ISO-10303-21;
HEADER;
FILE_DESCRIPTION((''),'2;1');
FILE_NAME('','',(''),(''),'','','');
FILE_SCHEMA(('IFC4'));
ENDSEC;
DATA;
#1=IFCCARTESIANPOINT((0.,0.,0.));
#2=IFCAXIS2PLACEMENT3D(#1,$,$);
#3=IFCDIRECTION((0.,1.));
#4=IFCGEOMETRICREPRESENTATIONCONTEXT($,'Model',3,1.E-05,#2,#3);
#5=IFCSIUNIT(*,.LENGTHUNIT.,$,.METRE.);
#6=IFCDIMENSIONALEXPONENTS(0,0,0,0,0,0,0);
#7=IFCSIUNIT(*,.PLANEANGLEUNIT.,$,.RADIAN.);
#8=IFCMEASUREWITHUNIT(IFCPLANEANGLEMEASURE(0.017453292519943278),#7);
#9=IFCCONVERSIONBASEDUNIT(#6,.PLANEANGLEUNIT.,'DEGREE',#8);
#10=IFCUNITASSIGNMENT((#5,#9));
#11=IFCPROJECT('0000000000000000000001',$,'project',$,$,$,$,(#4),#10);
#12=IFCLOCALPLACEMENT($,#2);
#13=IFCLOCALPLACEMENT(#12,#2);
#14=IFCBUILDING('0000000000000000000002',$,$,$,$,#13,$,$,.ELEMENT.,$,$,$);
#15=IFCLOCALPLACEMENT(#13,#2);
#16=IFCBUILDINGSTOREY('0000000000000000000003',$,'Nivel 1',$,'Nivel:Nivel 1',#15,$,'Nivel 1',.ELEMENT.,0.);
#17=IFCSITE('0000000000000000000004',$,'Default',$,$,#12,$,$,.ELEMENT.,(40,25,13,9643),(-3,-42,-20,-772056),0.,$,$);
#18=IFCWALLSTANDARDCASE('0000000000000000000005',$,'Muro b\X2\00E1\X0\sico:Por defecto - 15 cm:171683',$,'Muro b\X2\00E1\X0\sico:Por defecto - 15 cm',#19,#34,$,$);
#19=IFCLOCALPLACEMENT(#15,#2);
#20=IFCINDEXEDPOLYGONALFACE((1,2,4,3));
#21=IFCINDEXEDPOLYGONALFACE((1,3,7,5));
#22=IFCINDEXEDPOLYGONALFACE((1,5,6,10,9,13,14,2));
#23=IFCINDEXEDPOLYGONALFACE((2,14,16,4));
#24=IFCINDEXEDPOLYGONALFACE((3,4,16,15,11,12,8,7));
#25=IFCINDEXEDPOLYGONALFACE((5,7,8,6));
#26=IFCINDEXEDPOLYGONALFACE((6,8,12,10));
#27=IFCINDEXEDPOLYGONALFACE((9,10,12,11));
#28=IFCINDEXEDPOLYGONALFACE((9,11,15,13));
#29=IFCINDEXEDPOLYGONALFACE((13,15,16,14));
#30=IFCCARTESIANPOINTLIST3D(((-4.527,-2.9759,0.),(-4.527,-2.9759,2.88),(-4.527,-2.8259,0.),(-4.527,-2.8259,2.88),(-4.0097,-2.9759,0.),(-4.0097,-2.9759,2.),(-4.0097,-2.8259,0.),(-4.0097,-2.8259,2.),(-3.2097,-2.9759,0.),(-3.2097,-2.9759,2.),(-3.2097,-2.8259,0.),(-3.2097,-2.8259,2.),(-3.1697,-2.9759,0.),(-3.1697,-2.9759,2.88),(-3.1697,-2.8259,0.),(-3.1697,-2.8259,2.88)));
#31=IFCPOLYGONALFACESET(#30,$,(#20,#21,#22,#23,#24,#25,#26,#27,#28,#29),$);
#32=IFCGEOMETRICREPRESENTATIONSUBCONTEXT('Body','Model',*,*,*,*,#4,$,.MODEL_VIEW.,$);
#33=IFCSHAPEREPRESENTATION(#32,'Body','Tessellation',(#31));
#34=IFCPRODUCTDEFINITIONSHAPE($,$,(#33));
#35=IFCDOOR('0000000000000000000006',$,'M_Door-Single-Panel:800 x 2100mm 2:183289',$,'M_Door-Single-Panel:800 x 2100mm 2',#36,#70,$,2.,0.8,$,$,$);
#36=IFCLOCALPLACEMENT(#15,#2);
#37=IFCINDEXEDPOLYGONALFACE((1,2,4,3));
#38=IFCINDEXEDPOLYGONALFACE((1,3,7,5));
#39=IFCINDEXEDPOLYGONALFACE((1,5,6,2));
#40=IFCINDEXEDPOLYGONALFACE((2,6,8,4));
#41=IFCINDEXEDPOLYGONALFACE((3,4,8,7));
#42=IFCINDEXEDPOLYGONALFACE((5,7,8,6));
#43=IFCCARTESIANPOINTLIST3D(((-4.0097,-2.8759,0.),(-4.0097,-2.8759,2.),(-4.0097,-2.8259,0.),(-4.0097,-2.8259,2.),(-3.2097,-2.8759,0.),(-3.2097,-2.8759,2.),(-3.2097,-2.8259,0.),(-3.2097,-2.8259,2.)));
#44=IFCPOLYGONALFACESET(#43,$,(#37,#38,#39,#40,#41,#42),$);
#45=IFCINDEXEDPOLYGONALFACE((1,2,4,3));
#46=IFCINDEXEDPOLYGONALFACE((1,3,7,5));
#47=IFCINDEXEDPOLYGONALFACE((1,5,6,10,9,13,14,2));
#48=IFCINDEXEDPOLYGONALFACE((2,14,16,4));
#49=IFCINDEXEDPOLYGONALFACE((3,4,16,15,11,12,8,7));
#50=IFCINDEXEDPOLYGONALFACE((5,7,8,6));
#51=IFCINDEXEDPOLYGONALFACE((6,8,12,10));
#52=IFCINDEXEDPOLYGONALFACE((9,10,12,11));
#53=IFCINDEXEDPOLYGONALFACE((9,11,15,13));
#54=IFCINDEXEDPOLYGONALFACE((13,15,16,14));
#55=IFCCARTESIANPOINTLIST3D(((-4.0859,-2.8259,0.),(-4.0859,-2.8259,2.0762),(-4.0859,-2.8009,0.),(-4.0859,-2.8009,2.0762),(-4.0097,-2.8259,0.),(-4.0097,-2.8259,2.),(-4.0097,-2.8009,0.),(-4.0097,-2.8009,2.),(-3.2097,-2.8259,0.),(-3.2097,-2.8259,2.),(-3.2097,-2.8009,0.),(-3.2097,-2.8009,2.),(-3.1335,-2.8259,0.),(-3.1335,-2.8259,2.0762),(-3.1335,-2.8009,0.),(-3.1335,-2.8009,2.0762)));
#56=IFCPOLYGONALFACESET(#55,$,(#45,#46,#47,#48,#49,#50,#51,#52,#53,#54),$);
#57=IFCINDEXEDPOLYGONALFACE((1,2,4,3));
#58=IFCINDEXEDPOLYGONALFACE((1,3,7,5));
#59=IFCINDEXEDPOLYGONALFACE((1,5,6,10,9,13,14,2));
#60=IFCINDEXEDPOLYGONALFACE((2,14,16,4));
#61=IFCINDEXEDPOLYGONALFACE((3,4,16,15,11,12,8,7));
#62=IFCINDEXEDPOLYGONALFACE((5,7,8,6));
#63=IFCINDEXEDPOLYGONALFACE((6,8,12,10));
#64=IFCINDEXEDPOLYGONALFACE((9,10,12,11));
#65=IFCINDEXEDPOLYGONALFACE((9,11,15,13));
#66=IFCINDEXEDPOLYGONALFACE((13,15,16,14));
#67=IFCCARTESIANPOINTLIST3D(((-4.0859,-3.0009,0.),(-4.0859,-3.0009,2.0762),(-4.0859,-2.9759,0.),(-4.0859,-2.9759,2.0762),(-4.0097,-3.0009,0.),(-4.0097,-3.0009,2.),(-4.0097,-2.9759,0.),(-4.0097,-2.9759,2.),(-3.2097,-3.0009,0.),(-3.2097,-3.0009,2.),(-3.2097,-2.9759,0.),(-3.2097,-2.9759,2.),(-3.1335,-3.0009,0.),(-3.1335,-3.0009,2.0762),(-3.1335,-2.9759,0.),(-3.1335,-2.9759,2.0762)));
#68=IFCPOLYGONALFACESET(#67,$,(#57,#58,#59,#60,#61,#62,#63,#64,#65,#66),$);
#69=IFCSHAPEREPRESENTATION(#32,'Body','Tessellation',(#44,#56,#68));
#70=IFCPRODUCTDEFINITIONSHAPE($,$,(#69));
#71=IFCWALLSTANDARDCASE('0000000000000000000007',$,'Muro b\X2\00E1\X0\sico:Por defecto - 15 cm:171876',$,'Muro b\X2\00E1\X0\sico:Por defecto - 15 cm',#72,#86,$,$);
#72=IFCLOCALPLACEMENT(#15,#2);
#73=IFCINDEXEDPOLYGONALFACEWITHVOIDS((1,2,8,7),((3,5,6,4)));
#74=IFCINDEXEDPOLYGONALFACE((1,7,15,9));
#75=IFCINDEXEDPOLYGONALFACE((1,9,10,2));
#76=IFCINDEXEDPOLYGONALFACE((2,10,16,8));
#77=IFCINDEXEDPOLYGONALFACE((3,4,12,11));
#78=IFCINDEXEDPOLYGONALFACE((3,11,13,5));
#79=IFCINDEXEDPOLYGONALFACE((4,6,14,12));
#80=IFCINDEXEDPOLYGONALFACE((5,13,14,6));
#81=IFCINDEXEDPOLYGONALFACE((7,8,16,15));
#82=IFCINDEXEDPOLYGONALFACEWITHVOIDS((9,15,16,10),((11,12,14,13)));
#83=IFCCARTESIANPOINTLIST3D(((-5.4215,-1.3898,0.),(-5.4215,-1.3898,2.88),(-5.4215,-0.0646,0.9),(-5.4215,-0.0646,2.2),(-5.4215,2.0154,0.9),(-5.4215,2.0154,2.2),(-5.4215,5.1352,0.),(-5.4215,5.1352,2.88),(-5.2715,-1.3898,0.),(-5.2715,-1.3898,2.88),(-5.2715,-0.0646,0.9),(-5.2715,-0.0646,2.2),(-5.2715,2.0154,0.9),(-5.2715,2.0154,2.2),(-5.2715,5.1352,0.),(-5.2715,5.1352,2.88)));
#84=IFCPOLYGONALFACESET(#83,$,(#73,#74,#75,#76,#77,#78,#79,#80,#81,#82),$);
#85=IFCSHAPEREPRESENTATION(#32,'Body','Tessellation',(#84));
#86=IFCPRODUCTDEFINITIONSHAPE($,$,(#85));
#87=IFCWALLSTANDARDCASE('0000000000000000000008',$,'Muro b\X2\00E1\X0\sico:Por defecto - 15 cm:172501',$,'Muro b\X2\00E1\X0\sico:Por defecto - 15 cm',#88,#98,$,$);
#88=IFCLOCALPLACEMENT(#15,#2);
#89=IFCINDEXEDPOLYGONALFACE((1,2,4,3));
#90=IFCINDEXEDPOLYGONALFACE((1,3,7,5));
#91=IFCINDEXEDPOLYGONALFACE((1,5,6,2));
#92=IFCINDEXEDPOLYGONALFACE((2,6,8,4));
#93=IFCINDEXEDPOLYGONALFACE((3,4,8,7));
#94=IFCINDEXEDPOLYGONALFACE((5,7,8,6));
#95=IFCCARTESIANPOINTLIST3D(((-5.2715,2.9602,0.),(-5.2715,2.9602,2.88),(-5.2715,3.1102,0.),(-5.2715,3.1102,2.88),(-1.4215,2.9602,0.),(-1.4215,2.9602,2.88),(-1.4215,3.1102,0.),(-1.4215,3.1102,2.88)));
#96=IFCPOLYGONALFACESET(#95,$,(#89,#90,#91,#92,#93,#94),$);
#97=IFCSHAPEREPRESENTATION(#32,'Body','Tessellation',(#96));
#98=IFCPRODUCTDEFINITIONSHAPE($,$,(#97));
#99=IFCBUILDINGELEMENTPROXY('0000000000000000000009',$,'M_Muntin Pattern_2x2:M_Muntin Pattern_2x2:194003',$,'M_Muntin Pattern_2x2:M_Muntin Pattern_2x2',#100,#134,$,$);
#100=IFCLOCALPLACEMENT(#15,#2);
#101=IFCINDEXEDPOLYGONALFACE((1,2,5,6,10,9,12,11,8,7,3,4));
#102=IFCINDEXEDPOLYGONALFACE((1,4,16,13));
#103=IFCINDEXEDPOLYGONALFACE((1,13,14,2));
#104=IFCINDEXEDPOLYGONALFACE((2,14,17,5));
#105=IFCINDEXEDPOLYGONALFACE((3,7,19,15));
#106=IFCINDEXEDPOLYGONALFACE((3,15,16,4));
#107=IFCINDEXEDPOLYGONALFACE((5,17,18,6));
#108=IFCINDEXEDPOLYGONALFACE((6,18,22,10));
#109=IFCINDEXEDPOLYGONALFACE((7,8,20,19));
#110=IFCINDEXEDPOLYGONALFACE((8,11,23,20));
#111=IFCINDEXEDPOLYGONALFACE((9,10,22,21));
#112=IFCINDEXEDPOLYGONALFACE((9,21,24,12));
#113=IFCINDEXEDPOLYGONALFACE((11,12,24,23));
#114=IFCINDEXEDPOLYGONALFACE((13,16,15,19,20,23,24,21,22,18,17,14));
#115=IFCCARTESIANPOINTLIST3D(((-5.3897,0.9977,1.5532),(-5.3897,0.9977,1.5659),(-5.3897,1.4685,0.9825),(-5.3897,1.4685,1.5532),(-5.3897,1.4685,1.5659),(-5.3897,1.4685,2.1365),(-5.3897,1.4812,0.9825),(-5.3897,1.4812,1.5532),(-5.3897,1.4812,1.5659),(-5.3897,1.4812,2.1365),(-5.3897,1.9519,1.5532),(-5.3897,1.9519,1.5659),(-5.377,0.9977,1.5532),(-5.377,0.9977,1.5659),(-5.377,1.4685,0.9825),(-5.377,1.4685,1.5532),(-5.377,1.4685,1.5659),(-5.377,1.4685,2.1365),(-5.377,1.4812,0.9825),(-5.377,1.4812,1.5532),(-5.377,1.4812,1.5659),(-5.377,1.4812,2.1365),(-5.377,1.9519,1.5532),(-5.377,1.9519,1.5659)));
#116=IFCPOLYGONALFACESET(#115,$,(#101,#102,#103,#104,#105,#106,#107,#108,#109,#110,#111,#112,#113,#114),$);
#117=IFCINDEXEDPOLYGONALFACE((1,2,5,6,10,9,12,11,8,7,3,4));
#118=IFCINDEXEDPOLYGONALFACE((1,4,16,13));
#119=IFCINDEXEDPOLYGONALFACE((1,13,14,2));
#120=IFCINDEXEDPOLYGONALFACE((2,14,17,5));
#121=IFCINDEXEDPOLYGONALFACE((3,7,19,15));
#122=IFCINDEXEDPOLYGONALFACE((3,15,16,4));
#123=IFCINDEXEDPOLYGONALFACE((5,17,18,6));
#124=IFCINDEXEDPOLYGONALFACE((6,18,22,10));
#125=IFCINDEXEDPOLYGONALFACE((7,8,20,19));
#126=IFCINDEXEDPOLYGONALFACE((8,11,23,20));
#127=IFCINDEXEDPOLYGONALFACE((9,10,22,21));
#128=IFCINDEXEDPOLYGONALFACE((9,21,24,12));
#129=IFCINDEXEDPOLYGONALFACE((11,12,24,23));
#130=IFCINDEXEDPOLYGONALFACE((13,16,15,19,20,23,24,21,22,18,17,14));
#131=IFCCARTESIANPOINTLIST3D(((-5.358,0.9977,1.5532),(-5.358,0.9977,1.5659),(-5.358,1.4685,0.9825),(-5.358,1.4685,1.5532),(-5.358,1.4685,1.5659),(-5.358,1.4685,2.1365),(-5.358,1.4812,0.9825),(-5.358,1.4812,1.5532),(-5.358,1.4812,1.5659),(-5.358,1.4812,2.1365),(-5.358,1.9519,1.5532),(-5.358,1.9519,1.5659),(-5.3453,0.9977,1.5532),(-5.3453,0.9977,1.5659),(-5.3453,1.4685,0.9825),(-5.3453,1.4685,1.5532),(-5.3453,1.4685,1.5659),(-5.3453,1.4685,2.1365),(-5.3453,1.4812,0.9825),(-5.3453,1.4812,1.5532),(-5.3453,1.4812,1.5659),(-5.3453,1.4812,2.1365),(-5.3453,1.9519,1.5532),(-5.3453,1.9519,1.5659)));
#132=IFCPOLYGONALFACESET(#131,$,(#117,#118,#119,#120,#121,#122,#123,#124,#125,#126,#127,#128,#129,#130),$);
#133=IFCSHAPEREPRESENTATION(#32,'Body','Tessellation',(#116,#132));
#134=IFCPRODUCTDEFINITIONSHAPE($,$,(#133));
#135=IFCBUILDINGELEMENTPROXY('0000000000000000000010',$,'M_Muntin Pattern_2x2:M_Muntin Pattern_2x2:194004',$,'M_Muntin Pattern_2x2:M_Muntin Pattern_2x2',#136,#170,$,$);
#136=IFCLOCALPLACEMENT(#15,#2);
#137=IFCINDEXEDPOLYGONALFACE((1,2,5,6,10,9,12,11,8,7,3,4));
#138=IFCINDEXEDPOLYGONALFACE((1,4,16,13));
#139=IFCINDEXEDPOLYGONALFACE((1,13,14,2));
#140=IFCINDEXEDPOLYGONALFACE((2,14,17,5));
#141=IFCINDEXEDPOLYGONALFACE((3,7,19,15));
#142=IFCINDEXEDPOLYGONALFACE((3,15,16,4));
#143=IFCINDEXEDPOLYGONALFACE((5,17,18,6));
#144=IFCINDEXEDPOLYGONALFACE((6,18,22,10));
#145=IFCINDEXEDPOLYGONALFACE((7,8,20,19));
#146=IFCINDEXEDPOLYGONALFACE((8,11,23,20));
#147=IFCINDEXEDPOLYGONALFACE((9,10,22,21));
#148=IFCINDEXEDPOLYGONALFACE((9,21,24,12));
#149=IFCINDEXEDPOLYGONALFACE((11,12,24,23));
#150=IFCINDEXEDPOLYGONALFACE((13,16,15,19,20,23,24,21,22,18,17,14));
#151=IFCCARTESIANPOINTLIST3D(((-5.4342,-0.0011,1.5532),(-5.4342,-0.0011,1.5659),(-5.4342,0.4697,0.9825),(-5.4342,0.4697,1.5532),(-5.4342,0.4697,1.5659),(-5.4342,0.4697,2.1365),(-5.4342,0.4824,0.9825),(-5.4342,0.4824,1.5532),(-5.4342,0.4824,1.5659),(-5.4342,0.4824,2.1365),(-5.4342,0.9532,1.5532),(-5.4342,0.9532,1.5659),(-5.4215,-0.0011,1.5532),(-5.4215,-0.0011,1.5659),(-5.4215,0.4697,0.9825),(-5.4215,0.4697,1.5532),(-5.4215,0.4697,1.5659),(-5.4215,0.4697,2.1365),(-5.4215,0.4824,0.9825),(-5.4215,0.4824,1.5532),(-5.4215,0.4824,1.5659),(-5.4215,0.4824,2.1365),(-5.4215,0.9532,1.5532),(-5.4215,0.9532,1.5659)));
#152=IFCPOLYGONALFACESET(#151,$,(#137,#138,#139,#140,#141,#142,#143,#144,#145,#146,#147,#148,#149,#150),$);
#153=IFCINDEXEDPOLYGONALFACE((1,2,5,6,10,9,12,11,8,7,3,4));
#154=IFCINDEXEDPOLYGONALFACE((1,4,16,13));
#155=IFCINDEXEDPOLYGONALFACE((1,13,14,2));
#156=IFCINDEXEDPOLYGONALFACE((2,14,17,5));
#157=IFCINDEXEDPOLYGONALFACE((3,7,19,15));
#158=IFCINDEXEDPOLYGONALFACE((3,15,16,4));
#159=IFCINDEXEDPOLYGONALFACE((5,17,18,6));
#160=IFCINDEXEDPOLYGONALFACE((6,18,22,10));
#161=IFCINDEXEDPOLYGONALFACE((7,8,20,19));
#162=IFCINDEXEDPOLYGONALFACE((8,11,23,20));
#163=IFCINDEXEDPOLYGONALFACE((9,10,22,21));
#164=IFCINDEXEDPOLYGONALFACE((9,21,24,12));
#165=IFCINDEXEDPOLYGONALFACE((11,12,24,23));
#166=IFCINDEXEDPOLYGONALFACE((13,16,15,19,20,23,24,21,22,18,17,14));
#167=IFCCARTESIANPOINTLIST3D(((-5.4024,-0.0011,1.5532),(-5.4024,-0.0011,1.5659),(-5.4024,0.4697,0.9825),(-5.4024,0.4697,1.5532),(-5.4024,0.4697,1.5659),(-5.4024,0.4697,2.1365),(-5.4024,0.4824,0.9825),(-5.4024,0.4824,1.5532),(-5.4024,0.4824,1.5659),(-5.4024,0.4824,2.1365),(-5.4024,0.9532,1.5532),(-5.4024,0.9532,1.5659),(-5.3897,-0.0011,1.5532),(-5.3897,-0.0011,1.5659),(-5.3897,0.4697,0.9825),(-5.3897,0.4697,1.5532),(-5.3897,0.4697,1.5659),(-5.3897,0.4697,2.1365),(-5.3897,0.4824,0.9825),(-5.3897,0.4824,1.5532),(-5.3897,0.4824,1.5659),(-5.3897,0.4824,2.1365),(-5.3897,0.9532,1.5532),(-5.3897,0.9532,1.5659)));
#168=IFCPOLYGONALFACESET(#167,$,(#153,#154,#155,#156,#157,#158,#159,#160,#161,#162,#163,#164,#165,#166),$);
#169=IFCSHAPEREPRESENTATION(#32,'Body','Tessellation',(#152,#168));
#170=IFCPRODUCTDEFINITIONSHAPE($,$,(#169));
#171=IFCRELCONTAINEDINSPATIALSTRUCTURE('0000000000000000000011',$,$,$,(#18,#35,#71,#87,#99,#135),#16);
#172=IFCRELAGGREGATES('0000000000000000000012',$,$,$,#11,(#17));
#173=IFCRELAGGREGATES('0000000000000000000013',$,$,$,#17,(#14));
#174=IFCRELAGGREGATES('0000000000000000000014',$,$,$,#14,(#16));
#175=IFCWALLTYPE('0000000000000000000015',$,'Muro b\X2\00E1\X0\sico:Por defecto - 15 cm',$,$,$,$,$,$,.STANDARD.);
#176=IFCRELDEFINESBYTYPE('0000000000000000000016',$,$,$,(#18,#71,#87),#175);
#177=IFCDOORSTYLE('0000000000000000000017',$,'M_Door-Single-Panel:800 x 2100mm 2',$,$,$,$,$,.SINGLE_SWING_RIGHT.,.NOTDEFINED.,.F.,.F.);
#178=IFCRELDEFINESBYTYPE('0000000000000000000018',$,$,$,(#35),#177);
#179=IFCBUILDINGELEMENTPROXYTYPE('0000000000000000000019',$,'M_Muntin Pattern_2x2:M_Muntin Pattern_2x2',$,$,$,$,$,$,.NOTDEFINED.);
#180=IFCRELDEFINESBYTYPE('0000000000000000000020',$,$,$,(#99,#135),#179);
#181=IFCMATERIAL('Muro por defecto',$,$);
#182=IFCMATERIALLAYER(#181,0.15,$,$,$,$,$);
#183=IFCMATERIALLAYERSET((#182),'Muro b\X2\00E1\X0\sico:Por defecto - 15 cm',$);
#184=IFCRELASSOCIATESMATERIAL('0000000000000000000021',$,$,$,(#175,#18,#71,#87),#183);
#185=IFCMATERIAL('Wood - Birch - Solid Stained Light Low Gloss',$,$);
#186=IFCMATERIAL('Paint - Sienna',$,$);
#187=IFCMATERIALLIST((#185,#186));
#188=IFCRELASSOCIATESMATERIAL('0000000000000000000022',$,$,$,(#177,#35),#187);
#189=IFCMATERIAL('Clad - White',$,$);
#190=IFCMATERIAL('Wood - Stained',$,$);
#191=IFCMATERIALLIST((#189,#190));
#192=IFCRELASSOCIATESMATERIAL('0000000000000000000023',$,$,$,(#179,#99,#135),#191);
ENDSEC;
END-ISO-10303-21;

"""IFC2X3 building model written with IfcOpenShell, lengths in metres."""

from ifc_helpers import new_model, entity, si_unit, converted_unit, direction, frame, frame_2d, origin, origin_2d_with_axis, place, context, subcontext, project, spatial, polyline, rectangle, outline, extrude, clip, bounded_halfspace, source, transform, mapped, material, material_list, layer, layer_set, layer_usage, type_object, type_shapes, element, fill, save


model = new_model("IFC2X3")

# Units and contexts
model_context = context("Model", 3, precision=1e-05, world=origin(), true_north=direction((0.0, 1.0)))
body_context = subcontext(model_context, "Body", "Model", "MODEL_VIEW")
ifc_project = project(units=[si_unit("LENGTHUNIT", "METRE"), converted_unit("PLANEANGLEUNIT", "DEGREE", entity("IfcPlaneAngleMeasure", 0.017453292519943278), si_unit("PLANEANGLEUNIT", "RADIAN"), dimensions=[0, 0, 0, 0, 0, 0, 0])], contexts=[model_context])

# Site, building, storey
site_placement = place(None, origin())
site = spatial("IfcSite", under=ifc_project, at=site_placement, Name="Default", CompositionType="ELEMENT", RefLatitude=(40, 25, 13, 9643), RefLongitude=(-3, -42, -20, -772056), RefElevation=0.0)
building_placement = place(site_placement, origin())
building = spatial("IfcBuilding", under=site, at=building_placement, CompositionType="ELEMENT")
storey_placement = place(building_placement, origin())
storey = spatial("IfcBuildingStorey", under=building, at=storey_placement, Name="Nivel 1", ObjectType="Nivel:Nivel 1", LongName="Nivel 1", CompositionType="ELEMENT", Elevation=0.0)

# Shared definitions
ifc_material_1 = material(Name="Muro por defecto")
ifc_layer_1 = layer(ifc_material_1, 0.15)
ifc_layer_set_1 = layer_set([ifc_layer_1], Name="Muro básico:Por defecto - 15 cm")
wall_type = type_object("IfcWallType", Name="Muro básico:Por defecto - 15 cm", PredefinedType="STANDARD", material=ifc_layer_set_1)

# Wall, opening, door
ifc_material_2 = material(Name="Wood - Birch - Solid Stained Light Low Gloss")
ifc_material_3 = material(Name="Paint - Sienna")
ifc_material_list_1 = material_list([ifc_material_2, ifc_material_3])
ifc_layer_usage_1 = layer_usage(ifc_layer_set_1, "AXIS2", "POSITIVE", -0.075)
wall_1_placement = place(storey_placement, frame((-4.527, -2.9009, 0.0)))
wall_1 = element("IfcWallStandardCase", 1, at=wall_1_placement, inside=storey, type_object=wall_type, material=ifc_layer_usage_1, Name="Muro básico:Por defecto - 15 cm:171683", ObjectType="Muro básico:Por defecto - 15 cm", context=body_context, shape_type="Clipping", body=[
    clip(extrude(rectangle(XDim=1.3573, YDim=0.15, at=frame_2d((0.6786, 0.0), x_axis=(1.0, 0.0))), origin(), (0.0, 0.0, 1.0), 2.88), bounded_halfspace(frame((0.0, -0.075, 2.88), z_axis=(0.0, 0.0, -1.0), x_axis=(1.0, 0.0, 0.0)), True, frame((0.0, -0.075, 2.88)), polyline([(0.0, 0.0), (1.3573, 0.0), (1.3573, 0.15), (0.0, 0.15), (0.0, 0.0)]))),
])
opening_1_placement = place(wall_1_placement, frame((0.5173, -0.075, 0.0)))
opening_1 = element("IfcOpeningElement", 2, at=opening_1_placement, cuts=wall_1, ObjectType="Opening", context=body_context, shape_type="SweptSolid", body=[
    extrude(rectangle(XDim=0.8, YDim=2.0, at=frame_2d((1.0, 0.4), x_axis=(0.0, 1.0))), frame((0.0, 0.0, 0.0), z_axis=(0.0, 1.0, 0.0), x_axis=(0.0, 0.0, 1.0)), (0.0, 0.0, 1.0), 0.15),
])
door_style_1 = type_object("IfcDoorStyle", Name="M_Door-Single-Panel:800 x 2100mm 2", ConstructionType="NOTDEFINED", OperationType="SINGLE_SWING_RIGHT", ParameterTakesPrecedence=False, Sizeable=False, material=ifc_material_list_1)
shared_shape_1 = source(origin(), body_context, "Body", "SweptSolid", [
    extrude(rectangle(XDim=0.05, YDim=0.8, at=origin_2d_with_axis()), frame((0.4, 0.125, 0.0), z_axis=(0.0, 0.0, 1.0), x_axis=(0.0, 1.0, 0.0)), (0.0, 0.0, 1.0), 2.0),
    extrude(outline(polyline([(-0.4762, -1.0571), (0.4762, -1.0571), (0.4762, 1.0191), (0.4, 1.0191), (0.4, -0.981), (-0.4, -0.981), (-0.4, 1.0191), (-0.4762, 1.0191), (-0.4762, -1.0571)])), frame((0.4, 0.15, 1.0191), z_axis=(0.0, 1.0, 0.0), x_axis=(1.0, 0.0, 0.0)), (0.0, 0.0, 1.0), 0.025),
    extrude(outline(polyline([(-1.0571, -0.4762), (1.019, -0.4762), (1.019, -0.4), (-0.9809, -0.4), (-0.9809, 0.4), (1.019, 0.4), (1.019, 0.4762), (-1.0571, 0.4762), (-1.0571, -0.4762)])), frame((0.4, -0.025, 1.019), z_axis=(0.0, 1.0, 0.0), x_axis=(0.0, 0.0, -1.0)), (0.0, 0.0, 1.0), 0.025),
])
type_shapes(door_style_1, [shared_shape_1])
door_1_placement = place(opening_1_placement, origin())
door_1 = element("IfcDoor", 3, at=door_1_placement, inside=storey, type_object=door_style_1, material=ifc_material_list_1, Name="M_Door-Single-Panel:800 x 2100mm 2:183289", ObjectType="M_Door-Single-Panel:800 x 2100mm 2", OverallHeight=2.0, OverallWidth=0.8, context=body_context, shape_type="MappedRepresentation", body=[
    mapped(shared_shape_1, transform((0.0, 0.0, 0.0), scale=1.0)),
])
fill(opening_1, door_1)

# Wall, opening
ifc_layer_usage_2 = layer_usage(ifc_layer_set_1, "AXIS2", "NEGATIVE", 0.075)
wall_2_placement = place(storey_placement, frame((-5.3465, -1.3898, 0.0), z_axis=(0.0, 0.0, 1.0), x_axis=(0.0, 1.0, 0.0)))
wall_2 = element("IfcWallStandardCase", 4, at=wall_2_placement, inside=storey, type_object=wall_type, material=ifc_layer_usage_2, Name="Muro básico:Por defecto - 15 cm:171876", ObjectType="Muro básico:Por defecto - 15 cm", context=body_context, shape_type="Clipping", body=[
    clip(extrude(rectangle(XDim=6.525, YDim=0.15, at=frame_2d((3.2625, 0.0), x_axis=(-1.0, 0.0))), origin(), (0.0, 0.0, 1.0), 2.88), bounded_halfspace(frame((0.0, -0.075, 2.88), z_axis=(0.0, 0.0, -1.0), x_axis=(0.0, -1.0, 0.0)), True, frame((0.0, -0.075, 2.88)), polyline([(0.0, 0.0), (4.35, 0.0), (4.5, 0.0), (6.375, 0.0), (6.525, 0.0), (6.525, 0.15), (0.0, 0.15), (0.0, 0.0)]))),
])
opening_2_placement = place(wall_2_placement, frame((1.3252, -0.075, 0.9)))
element("IfcOpeningElement", 5, at=opening_2_placement, cuts=wall_2, ObjectType="Opening", context=body_context, shape_type="SweptSolid", body=[
    extrude(rectangle(XDim=1.3, YDim=2.08, at=frame_2d((0.65, 1.04), x_axis=(-1.0, 0.0))), frame((0.0, 0.0, 0.0), z_axis=(0.0, 1.0, 0.0), x_axis=(0.0, 0.0, 1.0)), (0.0, 0.0, 1.0), 0.15),
])

# Wall
ifc_layer_usage_3 = layer_usage(ifc_layer_set_1, "AXIS2", "POSITIVE", -0.075)
wall_3_placement = place(storey_placement, frame((-5.2715, 3.0352, 0.0)))
element("IfcWallStandardCase", 6, at=wall_3_placement, inside=storey, type_object=wall_type, material=ifc_layer_usage_3, Name="Muro básico:Por defecto - 15 cm:172501", ObjectType="Muro básico:Por defecto - 15 cm", context=body_context, shape_type="Clipping", body=[
    clip(extrude(rectangle(XDim=3.85, YDim=0.15, at=frame_2d((1.925, 0.0), x_axis=(-1.0, 0.0))), origin(), (0.0, 0.0, 1.0), 2.88), bounded_halfspace(frame((0.0, -0.075, 2.88), z_axis=(0.0, 0.0, -1.0), x_axis=(1.0, 0.0, 0.0)), True, frame((0.0, -0.075, 2.88)), polyline([(0.0, 0.0), (3.85, 0.0), (3.85, 0.15), (0.0, 0.15), (0.0, 0.0)]))),
])

# Building element proxies
ifc_material_4 = material(Name="Clad - White")
ifc_material_5 = material(Name="Wood - Stained")
ifc_material_list_2 = material_list([ifc_material_4, ifc_material_5])
building_element_proxy_type_1 = type_object("IfcBuildingElementProxyType", Name="M_Muntin Pattern_2x2:M_Muntin Pattern_2x2", PredefinedType="NOTDEFINED", material=ifc_material_list_2)
shared_shape_2 = source(origin(), body_context, "Body", "SweptSolid", [
    extrude(outline(polyline([(0.0064, -0.0064), (0.577, -0.0064), (0.577, 0.0063), (0.0064, 0.0063), (0.0064, 0.4771), (-0.0063, 0.4771), (-0.0063, 0.0063), (-0.577, 0.0063), (-0.577, -0.0064), (-0.0063, -0.0064), (-0.0063, -0.4771), (0.0064, -0.4771), (0.0064, -0.0064)])), frame((0.0, 0.0095, 0.577), z_axis=(0.0, 1.0, 0.0), x_axis=(0.0, 0.0, 1.0)), (0.0, 0.0, 1.0), 0.0127),
    extrude(outline(polyline([(0.0064, -0.0064), (0.577, -0.0064), (0.577, 0.0063), (0.0064, 0.0063), (0.0064, 0.4771), (-0.0063, 0.4771), (-0.0063, 0.0063), (-0.577, 0.0063), (-0.577, -0.0064), (-0.0063, -0.0064), (-0.0063, -0.4771), (0.0064, -0.4771), (0.0064, -0.0064)])), frame((0.0, -0.0222, 0.577), z_axis=(0.0, 1.0, 0.0), x_axis=(0.0, 0.0, 1.0)), (0.0, 0.0, 1.0), 0.0127),
])
type_shapes(building_element_proxy_type_1, [shared_shape_2])
for number, where, z_axis, x_axis, name in (
    (7, (-5.3675, 1.4748, 0.9825), (0.0, 0.0, 1.0), (0.0, 1.0, 0.0), "M_Muntin Pattern_2x2:M_Muntin Pattern_2x2:194003"),
    (8, (-5.412, 0.4761, 0.9825), (0.0, 0.0, 1.0), (0.0, 1.0, 0.0), "M_Muntin Pattern_2x2:M_Muntin Pattern_2x2:194004"),
):
    element("IfcBuildingElementProxy", number, at=place(storey_placement, frame(where, z_axis=z_axis, x_axis=x_axis)), inside=storey, type_object=building_element_proxy_type_1, material=ifc_material_list_2, Name=name, ObjectType="M_Muntin Pattern_2x2:M_Muntin Pattern_2x2", context=body_context, shape_type="MappedRepresentation", body=[
        mapped(shared_shape_2, transform((0.0, 0.0, 0.0), scale=1.0)),
    ])

save(model, "model.ifc")
